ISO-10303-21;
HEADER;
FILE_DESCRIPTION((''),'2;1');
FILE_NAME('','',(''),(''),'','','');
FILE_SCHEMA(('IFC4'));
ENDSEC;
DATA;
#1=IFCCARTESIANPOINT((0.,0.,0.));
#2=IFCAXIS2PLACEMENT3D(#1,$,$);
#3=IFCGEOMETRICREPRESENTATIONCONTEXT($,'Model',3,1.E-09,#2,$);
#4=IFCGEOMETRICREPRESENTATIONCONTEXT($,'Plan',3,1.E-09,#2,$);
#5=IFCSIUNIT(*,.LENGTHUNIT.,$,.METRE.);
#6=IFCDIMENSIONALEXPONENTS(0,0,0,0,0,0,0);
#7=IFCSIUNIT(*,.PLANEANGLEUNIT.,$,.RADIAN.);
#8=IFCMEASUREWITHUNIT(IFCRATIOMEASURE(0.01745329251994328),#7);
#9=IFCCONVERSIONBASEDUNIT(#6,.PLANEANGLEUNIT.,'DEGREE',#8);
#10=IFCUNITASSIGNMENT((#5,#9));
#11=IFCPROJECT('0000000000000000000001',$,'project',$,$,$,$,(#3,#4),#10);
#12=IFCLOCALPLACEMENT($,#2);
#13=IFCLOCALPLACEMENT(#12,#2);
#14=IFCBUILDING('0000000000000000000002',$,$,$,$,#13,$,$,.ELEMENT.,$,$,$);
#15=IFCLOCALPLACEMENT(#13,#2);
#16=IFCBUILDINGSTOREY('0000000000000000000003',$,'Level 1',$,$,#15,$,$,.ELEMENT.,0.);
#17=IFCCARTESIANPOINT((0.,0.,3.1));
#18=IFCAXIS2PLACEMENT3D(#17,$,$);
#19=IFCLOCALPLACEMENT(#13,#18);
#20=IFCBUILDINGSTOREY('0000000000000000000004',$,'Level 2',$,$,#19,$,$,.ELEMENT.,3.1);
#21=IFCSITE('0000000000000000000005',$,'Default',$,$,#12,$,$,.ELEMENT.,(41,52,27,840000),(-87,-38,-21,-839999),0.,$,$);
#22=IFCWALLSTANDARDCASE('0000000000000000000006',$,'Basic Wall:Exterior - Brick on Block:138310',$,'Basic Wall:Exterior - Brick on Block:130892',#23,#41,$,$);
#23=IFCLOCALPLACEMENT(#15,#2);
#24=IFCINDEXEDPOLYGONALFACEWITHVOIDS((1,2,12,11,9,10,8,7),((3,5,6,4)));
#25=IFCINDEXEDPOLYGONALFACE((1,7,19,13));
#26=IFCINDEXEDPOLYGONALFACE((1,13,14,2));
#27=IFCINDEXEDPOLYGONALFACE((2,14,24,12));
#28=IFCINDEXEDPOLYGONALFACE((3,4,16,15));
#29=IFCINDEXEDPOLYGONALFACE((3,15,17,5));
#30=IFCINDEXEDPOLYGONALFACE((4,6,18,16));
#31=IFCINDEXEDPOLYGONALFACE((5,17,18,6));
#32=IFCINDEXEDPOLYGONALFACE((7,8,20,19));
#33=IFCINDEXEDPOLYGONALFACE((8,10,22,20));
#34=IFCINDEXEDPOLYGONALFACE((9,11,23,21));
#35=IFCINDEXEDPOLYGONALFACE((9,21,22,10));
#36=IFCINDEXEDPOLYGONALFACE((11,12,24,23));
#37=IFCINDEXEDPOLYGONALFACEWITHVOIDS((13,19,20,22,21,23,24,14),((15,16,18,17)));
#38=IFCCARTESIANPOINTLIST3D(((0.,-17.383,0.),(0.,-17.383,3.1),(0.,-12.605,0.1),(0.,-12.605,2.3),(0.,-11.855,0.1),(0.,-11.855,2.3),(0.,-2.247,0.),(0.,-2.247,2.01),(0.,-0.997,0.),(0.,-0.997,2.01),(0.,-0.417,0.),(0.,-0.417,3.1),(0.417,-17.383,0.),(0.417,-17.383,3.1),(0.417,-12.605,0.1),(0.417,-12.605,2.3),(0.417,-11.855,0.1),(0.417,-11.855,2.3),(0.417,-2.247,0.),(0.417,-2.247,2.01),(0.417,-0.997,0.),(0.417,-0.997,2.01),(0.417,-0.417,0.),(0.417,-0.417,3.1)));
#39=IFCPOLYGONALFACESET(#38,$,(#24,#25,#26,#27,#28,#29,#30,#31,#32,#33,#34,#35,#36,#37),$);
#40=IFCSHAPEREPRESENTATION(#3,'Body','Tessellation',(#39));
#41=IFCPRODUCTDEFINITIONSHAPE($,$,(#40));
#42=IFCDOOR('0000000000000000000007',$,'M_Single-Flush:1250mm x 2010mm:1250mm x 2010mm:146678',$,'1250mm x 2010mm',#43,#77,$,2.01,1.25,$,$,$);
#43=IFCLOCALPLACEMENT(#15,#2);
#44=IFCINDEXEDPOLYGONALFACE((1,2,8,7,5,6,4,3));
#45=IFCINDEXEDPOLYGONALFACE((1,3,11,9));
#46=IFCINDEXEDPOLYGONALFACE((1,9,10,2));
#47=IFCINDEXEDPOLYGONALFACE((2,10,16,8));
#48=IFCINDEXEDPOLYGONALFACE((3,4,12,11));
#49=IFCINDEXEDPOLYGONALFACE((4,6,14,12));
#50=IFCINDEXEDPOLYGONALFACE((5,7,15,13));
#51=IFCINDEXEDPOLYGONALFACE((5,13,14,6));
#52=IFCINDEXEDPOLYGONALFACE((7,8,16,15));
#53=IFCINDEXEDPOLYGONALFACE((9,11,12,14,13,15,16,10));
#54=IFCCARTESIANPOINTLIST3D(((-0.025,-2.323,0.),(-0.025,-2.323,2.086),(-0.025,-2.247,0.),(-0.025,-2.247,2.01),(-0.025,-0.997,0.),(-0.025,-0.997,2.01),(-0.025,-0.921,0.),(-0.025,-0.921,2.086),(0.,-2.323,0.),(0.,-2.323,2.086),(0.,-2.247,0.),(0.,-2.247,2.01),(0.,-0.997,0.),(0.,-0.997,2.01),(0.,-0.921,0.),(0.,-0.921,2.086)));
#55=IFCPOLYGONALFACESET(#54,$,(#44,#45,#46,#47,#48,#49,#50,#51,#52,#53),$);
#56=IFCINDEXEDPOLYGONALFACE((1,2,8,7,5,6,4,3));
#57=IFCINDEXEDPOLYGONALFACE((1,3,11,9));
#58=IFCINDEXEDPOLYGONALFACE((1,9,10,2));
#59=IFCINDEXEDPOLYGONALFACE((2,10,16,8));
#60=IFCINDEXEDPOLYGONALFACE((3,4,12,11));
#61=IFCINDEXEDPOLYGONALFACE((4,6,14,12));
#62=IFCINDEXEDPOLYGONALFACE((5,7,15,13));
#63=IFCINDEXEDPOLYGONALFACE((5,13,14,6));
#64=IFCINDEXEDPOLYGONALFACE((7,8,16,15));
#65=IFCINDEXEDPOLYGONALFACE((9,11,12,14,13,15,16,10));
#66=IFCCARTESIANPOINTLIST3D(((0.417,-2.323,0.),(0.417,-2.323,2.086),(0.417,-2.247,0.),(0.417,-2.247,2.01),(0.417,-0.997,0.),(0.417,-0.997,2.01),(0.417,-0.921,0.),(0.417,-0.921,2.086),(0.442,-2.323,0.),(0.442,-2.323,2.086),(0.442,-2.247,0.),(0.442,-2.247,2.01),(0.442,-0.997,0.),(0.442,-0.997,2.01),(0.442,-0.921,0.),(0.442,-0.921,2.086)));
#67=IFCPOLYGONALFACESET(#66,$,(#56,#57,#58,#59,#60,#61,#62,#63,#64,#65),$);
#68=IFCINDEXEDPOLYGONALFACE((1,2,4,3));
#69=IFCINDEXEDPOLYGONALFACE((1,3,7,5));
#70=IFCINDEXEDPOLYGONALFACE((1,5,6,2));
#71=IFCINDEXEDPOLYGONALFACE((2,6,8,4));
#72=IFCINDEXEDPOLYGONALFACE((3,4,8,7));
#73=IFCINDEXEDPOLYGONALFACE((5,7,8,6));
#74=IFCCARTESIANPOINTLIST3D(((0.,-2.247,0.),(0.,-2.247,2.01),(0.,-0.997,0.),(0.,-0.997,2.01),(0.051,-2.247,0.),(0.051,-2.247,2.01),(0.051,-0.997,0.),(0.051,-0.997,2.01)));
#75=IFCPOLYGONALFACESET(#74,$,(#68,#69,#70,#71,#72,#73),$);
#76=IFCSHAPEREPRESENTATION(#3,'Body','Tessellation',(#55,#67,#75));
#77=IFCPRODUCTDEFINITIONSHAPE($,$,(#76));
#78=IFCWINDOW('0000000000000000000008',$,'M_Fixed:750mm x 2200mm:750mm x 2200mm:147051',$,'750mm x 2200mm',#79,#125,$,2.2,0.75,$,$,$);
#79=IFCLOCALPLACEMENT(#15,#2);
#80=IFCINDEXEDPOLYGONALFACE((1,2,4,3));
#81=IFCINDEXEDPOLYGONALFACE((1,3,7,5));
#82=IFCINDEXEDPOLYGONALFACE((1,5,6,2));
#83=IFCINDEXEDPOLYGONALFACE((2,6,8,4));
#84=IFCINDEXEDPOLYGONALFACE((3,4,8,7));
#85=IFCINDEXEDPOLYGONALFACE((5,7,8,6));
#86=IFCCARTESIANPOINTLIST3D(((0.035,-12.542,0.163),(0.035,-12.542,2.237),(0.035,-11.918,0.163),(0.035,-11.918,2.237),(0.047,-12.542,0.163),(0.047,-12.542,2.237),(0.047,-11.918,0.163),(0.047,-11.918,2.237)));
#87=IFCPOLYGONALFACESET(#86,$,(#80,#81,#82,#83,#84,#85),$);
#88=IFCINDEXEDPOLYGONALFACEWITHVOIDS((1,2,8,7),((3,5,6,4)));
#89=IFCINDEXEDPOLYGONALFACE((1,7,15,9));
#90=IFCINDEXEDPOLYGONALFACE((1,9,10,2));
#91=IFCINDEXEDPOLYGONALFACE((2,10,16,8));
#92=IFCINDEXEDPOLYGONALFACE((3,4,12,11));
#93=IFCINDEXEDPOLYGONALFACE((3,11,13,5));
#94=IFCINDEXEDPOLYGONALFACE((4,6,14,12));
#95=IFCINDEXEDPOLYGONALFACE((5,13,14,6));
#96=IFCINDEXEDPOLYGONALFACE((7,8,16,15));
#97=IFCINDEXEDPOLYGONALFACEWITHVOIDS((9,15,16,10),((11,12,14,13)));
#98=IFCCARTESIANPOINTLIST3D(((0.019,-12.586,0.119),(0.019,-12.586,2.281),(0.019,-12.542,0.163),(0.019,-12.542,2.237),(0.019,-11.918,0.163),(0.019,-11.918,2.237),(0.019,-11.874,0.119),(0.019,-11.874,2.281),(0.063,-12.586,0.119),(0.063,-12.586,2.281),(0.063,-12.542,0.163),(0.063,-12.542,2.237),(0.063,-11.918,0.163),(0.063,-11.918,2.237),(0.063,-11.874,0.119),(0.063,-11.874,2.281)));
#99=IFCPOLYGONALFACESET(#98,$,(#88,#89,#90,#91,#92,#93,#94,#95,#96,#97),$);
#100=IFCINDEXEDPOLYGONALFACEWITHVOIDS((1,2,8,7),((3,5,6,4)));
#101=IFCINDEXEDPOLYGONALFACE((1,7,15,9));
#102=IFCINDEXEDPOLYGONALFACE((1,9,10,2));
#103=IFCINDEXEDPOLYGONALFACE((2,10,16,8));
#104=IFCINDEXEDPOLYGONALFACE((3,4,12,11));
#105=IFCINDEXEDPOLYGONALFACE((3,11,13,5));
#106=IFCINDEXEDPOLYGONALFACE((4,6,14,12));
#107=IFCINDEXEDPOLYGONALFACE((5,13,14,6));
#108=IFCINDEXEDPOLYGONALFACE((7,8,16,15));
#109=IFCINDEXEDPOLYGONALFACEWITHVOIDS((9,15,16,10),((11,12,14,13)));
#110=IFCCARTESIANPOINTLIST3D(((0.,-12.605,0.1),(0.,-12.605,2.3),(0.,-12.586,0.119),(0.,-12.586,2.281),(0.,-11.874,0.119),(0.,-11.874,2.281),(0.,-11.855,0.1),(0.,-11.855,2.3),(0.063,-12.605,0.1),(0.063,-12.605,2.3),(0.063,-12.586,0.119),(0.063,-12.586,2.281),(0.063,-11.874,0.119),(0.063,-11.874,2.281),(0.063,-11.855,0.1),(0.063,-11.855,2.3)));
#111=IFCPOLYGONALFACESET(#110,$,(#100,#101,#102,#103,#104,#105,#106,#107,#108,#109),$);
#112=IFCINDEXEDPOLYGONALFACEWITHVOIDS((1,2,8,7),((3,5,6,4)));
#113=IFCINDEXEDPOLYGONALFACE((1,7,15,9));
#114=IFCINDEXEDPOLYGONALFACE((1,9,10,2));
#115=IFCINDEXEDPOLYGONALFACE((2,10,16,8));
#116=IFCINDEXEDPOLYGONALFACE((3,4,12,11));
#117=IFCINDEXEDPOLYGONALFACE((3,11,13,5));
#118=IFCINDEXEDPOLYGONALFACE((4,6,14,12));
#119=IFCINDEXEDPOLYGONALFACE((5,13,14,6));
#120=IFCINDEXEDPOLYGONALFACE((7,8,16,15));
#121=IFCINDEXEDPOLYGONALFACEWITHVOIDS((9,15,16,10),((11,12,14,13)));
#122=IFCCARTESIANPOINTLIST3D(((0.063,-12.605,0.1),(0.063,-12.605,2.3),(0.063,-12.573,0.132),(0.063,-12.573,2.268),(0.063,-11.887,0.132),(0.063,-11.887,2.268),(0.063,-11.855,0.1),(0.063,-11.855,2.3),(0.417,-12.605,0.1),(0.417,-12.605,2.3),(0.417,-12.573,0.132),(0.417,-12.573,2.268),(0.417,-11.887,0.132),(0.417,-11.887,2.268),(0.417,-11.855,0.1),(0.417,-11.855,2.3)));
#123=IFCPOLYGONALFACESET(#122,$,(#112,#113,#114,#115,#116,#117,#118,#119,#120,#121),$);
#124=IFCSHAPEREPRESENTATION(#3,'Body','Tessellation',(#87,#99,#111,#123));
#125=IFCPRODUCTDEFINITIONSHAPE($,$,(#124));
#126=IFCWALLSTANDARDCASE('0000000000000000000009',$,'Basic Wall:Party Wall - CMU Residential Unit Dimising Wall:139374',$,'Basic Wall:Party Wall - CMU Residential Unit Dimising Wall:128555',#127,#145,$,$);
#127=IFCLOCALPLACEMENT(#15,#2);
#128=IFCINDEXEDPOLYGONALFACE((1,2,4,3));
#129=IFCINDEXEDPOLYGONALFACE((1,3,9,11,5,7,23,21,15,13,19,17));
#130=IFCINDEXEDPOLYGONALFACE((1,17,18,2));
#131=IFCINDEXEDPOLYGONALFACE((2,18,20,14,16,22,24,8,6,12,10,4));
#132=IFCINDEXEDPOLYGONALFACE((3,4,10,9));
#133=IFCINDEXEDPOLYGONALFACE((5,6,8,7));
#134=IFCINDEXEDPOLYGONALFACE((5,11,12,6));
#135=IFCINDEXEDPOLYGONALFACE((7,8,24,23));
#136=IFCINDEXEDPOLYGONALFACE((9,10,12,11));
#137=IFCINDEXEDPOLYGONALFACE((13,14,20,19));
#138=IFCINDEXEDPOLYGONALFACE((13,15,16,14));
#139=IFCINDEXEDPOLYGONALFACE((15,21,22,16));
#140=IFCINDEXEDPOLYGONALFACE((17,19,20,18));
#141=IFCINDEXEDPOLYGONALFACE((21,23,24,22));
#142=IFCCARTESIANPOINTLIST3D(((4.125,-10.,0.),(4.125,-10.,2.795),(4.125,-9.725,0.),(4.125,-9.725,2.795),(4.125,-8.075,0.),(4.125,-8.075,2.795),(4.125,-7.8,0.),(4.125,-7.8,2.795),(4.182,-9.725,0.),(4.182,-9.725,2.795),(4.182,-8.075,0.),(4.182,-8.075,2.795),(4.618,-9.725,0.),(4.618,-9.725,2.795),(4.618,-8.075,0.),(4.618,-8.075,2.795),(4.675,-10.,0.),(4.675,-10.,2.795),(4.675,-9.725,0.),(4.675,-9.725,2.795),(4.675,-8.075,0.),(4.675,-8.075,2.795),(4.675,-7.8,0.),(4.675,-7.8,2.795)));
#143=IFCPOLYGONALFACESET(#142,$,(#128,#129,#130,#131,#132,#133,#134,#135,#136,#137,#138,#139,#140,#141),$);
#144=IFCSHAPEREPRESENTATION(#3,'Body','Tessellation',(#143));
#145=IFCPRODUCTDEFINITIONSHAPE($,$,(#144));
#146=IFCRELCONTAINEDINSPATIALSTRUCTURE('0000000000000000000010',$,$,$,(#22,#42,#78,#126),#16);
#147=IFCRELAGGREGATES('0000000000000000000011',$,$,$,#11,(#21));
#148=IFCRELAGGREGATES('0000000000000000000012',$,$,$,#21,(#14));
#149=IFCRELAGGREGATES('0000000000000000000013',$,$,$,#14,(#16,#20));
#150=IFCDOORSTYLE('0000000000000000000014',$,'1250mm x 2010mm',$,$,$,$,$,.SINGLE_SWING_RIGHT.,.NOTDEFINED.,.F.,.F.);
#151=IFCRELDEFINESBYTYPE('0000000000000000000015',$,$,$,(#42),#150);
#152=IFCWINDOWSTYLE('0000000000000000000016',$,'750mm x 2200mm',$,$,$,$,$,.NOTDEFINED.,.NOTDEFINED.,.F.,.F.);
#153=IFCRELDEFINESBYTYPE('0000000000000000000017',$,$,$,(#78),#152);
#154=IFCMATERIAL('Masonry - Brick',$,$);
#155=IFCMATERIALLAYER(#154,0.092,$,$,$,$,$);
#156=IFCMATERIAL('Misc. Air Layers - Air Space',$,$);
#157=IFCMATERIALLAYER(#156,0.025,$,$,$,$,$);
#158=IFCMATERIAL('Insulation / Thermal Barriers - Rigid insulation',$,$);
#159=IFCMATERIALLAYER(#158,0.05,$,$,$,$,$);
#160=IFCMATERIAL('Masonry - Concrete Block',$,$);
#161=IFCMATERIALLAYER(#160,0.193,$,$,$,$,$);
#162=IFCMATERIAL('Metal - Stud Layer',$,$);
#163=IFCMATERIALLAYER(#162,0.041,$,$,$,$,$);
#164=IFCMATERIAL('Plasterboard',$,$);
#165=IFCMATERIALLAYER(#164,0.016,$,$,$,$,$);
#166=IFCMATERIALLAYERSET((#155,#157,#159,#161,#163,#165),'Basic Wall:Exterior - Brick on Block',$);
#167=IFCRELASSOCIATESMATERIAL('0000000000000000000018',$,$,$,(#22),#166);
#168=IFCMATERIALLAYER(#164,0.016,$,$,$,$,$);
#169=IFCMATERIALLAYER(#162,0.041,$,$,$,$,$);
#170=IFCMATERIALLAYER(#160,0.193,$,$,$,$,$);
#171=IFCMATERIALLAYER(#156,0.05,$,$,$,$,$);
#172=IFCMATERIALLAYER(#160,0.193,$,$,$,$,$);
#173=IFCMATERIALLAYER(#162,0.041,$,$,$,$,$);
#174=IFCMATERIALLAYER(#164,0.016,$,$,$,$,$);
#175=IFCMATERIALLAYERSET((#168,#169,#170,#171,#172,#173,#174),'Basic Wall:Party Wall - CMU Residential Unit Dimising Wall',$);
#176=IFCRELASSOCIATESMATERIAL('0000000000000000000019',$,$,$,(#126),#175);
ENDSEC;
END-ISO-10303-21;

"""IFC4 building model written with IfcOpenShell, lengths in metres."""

from ifc_helpers import new_model, entity, si_unit, converted_unit, frame, frame_2d, origin, origin_2d_with_axis, place, context, project, spatial, polyline, rectangle, outline, extrude, clip, bounded_halfspace, source, transform, mapped, material, layer, layer_set, layer_usage, type_object, type_shapes, element, fill, save


model = new_model("IFC4")

# Units and contexts
model_context = context("Model", 3, precision=1e-09, world=origin())
plan_context = context("Plan", 3, precision=1e-09, world=origin())
ifc_project = project(units=[si_unit("LENGTHUNIT", "METRE"), converted_unit("PLANEANGLEUNIT", "DEGREE", entity("IfcRatioMeasure", 0.01745329251994328), si_unit("PLANEANGLEUNIT", "RADIAN"), dimensions=[0, 0, 0, 0, 0, 0, 0])], contexts=[model_context, plan_context])

# Site, building, storey
site_placement = place(None, origin())
site = spatial("IfcSite", under=ifc_project, at=site_placement, Name="Default", CompositionType="ELEMENT", RefLatitude=(41, 52, 27, 840000), RefLongitude=(-87, -38, -21, -839999), RefElevation=0.0)
building_placement = place(site_placement, origin())
building = spatial("IfcBuilding", under=site, at=building_placement, CompositionType="ELEMENT")
storey_1_placement = place(building_placement, origin())
storey_1 = spatial("IfcBuildingStorey", under=building, at=storey_1_placement, Name="Level 1", CompositionType="ELEMENT", Elevation=0.0)

# Shared definitions
ifc_material_1 = material(Name="Masonry - Brick")
ifc_layer_1 = layer(ifc_material_1, 0.092)
ifc_material_2 = material(Name="Misc. Air Layers - Air Space")
ifc_layer_2 = layer(ifc_material_2, 0.025)
ifc_material_3 = material(Name="Insulation / Thermal Barriers - Rigid insulation")
ifc_layer_3 = layer(ifc_material_3, 0.05)
ifc_material_4 = material(Name="Masonry - Concrete Block")
ifc_layer_4 = layer(ifc_material_4, 0.193)
ifc_material_5 = material(Name="Metal - Stud Layer")
ifc_layer_5 = layer(ifc_material_5, 0.041)
ifc_material_6 = material(Name="Plasterboard")
ifc_layer_6 = layer(ifc_material_6, 0.016)
ifc_layer_set_1 = layer_set([ifc_layer_1, ifc_layer_2, ifc_layer_3, ifc_layer_4, ifc_layer_5, ifc_layer_6], Name="Basic Wall:Exterior - Brick on Block")

# Wall, openings, door, window
ifc_layer_usage_1 = layer_usage(ifc_layer_set_1, "AXIS2", "NEGATIVE", 0.2085)
wall_1_placement = place(storey_1_placement, frame((0.2085, -17.383, 0.0), z_axis=(0.0, 0.0, 1.0), x_axis=(0.0, 1.0, 0.0)))
wall_1 = element("IfcWallStandardCase", 1, at=wall_1_placement, inside=storey_1, material=ifc_layer_usage_1, Name="Basic Wall:Exterior - Brick on Block:138310", ObjectType="Basic Wall:Exterior - Brick on Block:130892", context=model_context, shape_type="SweptSolid", body=[
    extrude(rectangle(XDim=16.966, YDim=0.417, at=frame_2d((8.483, 0.0), x_axis=(-1.0, 0.0))), origin(), (0.0, 0.0, 1.0), 3.1),
])
opening_1_placement = place(wall_1_placement, frame((15.136, -0.2085, 0.0)))
opening_1 = element("IfcOpeningElement", 2, at=opening_1_placement, cuts=wall_1, ObjectType="Opening", context=model_context, shape_type="SweptSolid", body=[
    extrude(rectangle(XDim=1.25, YDim=2.01, at=frame_2d((1.005, 0.625), x_axis=(0.0, 1.0))), frame((0.0, 0.0, 0.0), z_axis=(0.0, 1.0, 0.0), x_axis=(0.0, 0.0, 1.0)), (0.0, 0.0, 1.0), 0.417),
])
opening_2_placement = place(wall_1_placement, frame((4.778, -0.2085, 0.1)))
opening_2 = element("IfcOpeningElement", 3, at=opening_2_placement, cuts=wall_1, ObjectType="Opening", context=model_context, shape_type="SweptSolid", body=[
    extrude(rectangle(XDim=2.2, YDim=0.75, at=frame_2d((1.1, 0.375), x_axis=(1.0, 0.0))), frame((0.0, 0.0, 0.0), z_axis=(0.0, 1.0, 0.0), x_axis=(0.0, 0.0, 1.0)), (0.0, 0.0, 1.0), 0.417),
])
door_style_1 = type_object("IfcDoorStyle", Name="1250mm x 2010mm", ConstructionType="NOTDEFINED", OperationType="SINGLE_SWING_RIGHT", ParameterTakesPrecedence=False, Sizeable=False)
shared_shape_1 = source(origin(), model_context, "Body", "SweptSolid", [
    extrude(outline(polyline([(-0.701, -1.062), (0.701, -1.062), (0.701, 1.024), (0.625, 1.024), (0.625, -0.986), (-0.625, -0.986), (-0.625, 1.024), (-0.701, 1.024), (-0.701, -1.062)])), frame((0.625, 0.417, 1.024), z_axis=(0.0, 1.0, 0.0), x_axis=(1.0, 0.0, 0.0)), (0.0, 0.0, 1.0), 0.025),
    extrude(outline(polyline([(-1.062, -0.701), (1.024, -0.701), (1.024, -0.625), (-0.986, -0.625), (-0.986, 0.625), (1.024, 0.625), (1.024, 0.701), (-1.062, 0.701), (-1.062, -0.701)])), frame((0.625, -0.025, 1.024), z_axis=(0.0, 1.0, 0.0), x_axis=(0.0, 0.0, -1.0)), (0.0, 0.0, 1.0), 0.025),
    extrude(rectangle(XDim=0.051, YDim=1.25, at=origin_2d_with_axis()), frame((0.625, 0.3915, 0.0), z_axis=(0.0, 0.0, 1.0), x_axis=(0.0, 1.0, 0.0)), (0.0, 0.0, 1.0), 2.01),
])
type_shapes(door_style_1, [shared_shape_1])
door_1_placement = place(opening_1_placement, origin())
door_1 = element("IfcDoor", 4, at=door_1_placement, inside=storey_1, type_object=door_style_1, Name="M_Single-Flush:1250mm x 2010mm:1250mm x 2010mm:146678", ObjectType="1250mm x 2010mm", OverallHeight=2.01, OverallWidth=1.25, context=model_context, shape_type="MappedRepresentation", body=[
    mapped(shared_shape_1, transform((0.0, 0.0, 0.0), scale=1.0)),
])
fill(opening_1, door_1)
window_style_1 = type_object("IfcWindowStyle", Name="750mm x 2200mm", ConstructionType="NOTDEFINED", OperationType="NOTDEFINED", ParameterTakesPrecedence=False, Sizeable=False)
shared_shape_2 = source(origin(), model_context, "Body", "SweptSolid", [
    extrude(rectangle(XDim=0.012, YDim=0.624, at=origin_2d_with_axis()), frame((0.375, 0.376, 0.063), z_axis=(0.0, 0.0, 1.0), x_axis=(0.0, -1.0, 0.0)), (0.0, 0.0, 1.0), 2.074),
    extrude(outline(polyline([(-0.356, -1.081), (0.356, -1.081), (0.356, 1.081), (-0.356, 1.081), (-0.356, -1.081)]), holes=[polyline([(-0.312, -1.037), (-0.312, 1.037), (0.312, 1.037), (0.312, -1.037), (-0.312, -1.037)])]), frame((0.375, 0.354, 1.1), z_axis=(0.0, 1.0, 0.0), x_axis=(1.0, 0.0, 0.0)), (0.0, 0.0, 1.0), 0.044),
    extrude(outline(polyline([(-0.375, -1.1), (0.375, -1.1), (0.375, 1.1), (-0.375, 1.1), (-0.375, -1.1)]), holes=[polyline([(-0.356, -1.081), (-0.356, 1.081), (0.356, 1.081), (0.356, -1.081), (-0.356, -1.081)])]), frame((0.375, 0.354, 1.1), z_axis=(0.0, 1.0, 0.0), x_axis=(1.0, 0.0, 0.0)), (0.0, 0.0, 1.0), 0.063),
    extrude(outline(polyline([(-0.375, -1.1), (0.375, -1.1), (0.375, 1.1), (-0.375, 1.1), (-0.375, -1.1)]), holes=[polyline([(-0.343, -1.068), (-0.343, 1.068), (0.343, 1.068), (0.343, -1.068), (-0.343, -1.068)])]), frame((0.375, 0.0, 1.1), z_axis=(0.0, 1.0, 0.0), x_axis=(1.0, 0.0, 0.0)), (0.0, 0.0, 1.0), 0.354),
])
type_shapes(window_style_1, [shared_shape_2])
window_1_placement = place(opening_2_placement, origin())
window_1 = element("IfcWindow", 5, at=window_1_placement, inside=storey_1, type_object=window_style_1, Name="M_Fixed:750mm x 2200mm:750mm x 2200mm:147051", ObjectType="750mm x 2200mm", OverallHeight=2.2, OverallWidth=0.75, context=model_context, shape_type="MappedRepresentation", body=[
    mapped(shared_shape_2, transform((0.0, 0.0, 0.0), scale=1.0)),
])
fill(opening_2, window_1)

# Wall
ifc_layer_7 = layer(ifc_material_6, 0.016)
ifc_layer_8 = layer(ifc_material_5, 0.041)
ifc_layer_9 = layer(ifc_material_4, 0.193)
ifc_layer_10 = layer(ifc_material_2, 0.05)
ifc_layer_11 = layer(ifc_material_4, 0.193)
ifc_layer_12 = layer(ifc_material_5, 0.041)
ifc_layer_13 = layer(ifc_material_6, 0.016)
ifc_layer_set_2 = layer_set([ifc_layer_7, ifc_layer_8, ifc_layer_9, ifc_layer_10, ifc_layer_11, ifc_layer_12, ifc_layer_13], Name="Basic Wall:Party Wall - CMU Residential Unit Dimising Wall")
ifc_layer_usage_2 = layer_usage(ifc_layer_set_2, "AXIS2", "NEGATIVE", 0.275)
wall_2_placement = place(storey_1_placement, frame((4.4, -10.0, 0.0), z_axis=(0.0, 0.0, 1.0), x_axis=(0.0, 1.0, 0.0)))
element("IfcWallStandardCase", 6, at=wall_2_placement, inside=storey_1, material=ifc_layer_usage_2, Name="Basic Wall:Party Wall - CMU Residential Unit Dimising Wall:139374", ObjectType="Basic Wall:Party Wall - CMU Residential Unit Dimising Wall:128555", context=model_context, shape_type="Clipping", body=[
    clip(clip(extrude(rectangle(XDim=2.2, YDim=0.55, at=frame_2d((1.1, 0.0), x_axis=(-1.0, 0.0))), origin(), (0.0, 0.0, 1.0), 2.795), bounded_halfspace(frame((1.925, 0.218, 0.0), z_axis=(0.0, -1.0, 0.0), x_axis=(1.0, 0.0, 0.0)), True, frame((1.925, 0.218, 0.0), z_axis=(0.0, -1.0, 0.0), x_axis=(1.0, 0.0, 0.0)), polyline([(0.0, 0.0), (0.0, 2.795), (-1.65, 2.795), (-1.65, 0.0), (0.0, 0.0)]))), bounded_halfspace(frame((0.275, -0.218, 0.0), z_axis=(0.0, 1.0, 0.0), x_axis=(-1.0, 0.0, 0.0)), True, frame((0.275, -0.218, 0.0), z_axis=(0.0, 1.0, 0.0), x_axis=(-1.0, 0.0, 0.0)), polyline([(0.0, 0.0), (0.0, 2.795), (-1.65, 2.795), (-1.65, 0.0), (0.0, 0.0)]))),
])

# Shared definitions
storey_2_placement = place(building_placement, frame((0.0, 0.0, 3.1)))
storey_2 = spatial("IfcBuildingStorey", under=building, at=storey_2_placement, Name="Level 2", CompositionType="ELEMENT", Elevation=3.1)

save(model, "model.ifc")
